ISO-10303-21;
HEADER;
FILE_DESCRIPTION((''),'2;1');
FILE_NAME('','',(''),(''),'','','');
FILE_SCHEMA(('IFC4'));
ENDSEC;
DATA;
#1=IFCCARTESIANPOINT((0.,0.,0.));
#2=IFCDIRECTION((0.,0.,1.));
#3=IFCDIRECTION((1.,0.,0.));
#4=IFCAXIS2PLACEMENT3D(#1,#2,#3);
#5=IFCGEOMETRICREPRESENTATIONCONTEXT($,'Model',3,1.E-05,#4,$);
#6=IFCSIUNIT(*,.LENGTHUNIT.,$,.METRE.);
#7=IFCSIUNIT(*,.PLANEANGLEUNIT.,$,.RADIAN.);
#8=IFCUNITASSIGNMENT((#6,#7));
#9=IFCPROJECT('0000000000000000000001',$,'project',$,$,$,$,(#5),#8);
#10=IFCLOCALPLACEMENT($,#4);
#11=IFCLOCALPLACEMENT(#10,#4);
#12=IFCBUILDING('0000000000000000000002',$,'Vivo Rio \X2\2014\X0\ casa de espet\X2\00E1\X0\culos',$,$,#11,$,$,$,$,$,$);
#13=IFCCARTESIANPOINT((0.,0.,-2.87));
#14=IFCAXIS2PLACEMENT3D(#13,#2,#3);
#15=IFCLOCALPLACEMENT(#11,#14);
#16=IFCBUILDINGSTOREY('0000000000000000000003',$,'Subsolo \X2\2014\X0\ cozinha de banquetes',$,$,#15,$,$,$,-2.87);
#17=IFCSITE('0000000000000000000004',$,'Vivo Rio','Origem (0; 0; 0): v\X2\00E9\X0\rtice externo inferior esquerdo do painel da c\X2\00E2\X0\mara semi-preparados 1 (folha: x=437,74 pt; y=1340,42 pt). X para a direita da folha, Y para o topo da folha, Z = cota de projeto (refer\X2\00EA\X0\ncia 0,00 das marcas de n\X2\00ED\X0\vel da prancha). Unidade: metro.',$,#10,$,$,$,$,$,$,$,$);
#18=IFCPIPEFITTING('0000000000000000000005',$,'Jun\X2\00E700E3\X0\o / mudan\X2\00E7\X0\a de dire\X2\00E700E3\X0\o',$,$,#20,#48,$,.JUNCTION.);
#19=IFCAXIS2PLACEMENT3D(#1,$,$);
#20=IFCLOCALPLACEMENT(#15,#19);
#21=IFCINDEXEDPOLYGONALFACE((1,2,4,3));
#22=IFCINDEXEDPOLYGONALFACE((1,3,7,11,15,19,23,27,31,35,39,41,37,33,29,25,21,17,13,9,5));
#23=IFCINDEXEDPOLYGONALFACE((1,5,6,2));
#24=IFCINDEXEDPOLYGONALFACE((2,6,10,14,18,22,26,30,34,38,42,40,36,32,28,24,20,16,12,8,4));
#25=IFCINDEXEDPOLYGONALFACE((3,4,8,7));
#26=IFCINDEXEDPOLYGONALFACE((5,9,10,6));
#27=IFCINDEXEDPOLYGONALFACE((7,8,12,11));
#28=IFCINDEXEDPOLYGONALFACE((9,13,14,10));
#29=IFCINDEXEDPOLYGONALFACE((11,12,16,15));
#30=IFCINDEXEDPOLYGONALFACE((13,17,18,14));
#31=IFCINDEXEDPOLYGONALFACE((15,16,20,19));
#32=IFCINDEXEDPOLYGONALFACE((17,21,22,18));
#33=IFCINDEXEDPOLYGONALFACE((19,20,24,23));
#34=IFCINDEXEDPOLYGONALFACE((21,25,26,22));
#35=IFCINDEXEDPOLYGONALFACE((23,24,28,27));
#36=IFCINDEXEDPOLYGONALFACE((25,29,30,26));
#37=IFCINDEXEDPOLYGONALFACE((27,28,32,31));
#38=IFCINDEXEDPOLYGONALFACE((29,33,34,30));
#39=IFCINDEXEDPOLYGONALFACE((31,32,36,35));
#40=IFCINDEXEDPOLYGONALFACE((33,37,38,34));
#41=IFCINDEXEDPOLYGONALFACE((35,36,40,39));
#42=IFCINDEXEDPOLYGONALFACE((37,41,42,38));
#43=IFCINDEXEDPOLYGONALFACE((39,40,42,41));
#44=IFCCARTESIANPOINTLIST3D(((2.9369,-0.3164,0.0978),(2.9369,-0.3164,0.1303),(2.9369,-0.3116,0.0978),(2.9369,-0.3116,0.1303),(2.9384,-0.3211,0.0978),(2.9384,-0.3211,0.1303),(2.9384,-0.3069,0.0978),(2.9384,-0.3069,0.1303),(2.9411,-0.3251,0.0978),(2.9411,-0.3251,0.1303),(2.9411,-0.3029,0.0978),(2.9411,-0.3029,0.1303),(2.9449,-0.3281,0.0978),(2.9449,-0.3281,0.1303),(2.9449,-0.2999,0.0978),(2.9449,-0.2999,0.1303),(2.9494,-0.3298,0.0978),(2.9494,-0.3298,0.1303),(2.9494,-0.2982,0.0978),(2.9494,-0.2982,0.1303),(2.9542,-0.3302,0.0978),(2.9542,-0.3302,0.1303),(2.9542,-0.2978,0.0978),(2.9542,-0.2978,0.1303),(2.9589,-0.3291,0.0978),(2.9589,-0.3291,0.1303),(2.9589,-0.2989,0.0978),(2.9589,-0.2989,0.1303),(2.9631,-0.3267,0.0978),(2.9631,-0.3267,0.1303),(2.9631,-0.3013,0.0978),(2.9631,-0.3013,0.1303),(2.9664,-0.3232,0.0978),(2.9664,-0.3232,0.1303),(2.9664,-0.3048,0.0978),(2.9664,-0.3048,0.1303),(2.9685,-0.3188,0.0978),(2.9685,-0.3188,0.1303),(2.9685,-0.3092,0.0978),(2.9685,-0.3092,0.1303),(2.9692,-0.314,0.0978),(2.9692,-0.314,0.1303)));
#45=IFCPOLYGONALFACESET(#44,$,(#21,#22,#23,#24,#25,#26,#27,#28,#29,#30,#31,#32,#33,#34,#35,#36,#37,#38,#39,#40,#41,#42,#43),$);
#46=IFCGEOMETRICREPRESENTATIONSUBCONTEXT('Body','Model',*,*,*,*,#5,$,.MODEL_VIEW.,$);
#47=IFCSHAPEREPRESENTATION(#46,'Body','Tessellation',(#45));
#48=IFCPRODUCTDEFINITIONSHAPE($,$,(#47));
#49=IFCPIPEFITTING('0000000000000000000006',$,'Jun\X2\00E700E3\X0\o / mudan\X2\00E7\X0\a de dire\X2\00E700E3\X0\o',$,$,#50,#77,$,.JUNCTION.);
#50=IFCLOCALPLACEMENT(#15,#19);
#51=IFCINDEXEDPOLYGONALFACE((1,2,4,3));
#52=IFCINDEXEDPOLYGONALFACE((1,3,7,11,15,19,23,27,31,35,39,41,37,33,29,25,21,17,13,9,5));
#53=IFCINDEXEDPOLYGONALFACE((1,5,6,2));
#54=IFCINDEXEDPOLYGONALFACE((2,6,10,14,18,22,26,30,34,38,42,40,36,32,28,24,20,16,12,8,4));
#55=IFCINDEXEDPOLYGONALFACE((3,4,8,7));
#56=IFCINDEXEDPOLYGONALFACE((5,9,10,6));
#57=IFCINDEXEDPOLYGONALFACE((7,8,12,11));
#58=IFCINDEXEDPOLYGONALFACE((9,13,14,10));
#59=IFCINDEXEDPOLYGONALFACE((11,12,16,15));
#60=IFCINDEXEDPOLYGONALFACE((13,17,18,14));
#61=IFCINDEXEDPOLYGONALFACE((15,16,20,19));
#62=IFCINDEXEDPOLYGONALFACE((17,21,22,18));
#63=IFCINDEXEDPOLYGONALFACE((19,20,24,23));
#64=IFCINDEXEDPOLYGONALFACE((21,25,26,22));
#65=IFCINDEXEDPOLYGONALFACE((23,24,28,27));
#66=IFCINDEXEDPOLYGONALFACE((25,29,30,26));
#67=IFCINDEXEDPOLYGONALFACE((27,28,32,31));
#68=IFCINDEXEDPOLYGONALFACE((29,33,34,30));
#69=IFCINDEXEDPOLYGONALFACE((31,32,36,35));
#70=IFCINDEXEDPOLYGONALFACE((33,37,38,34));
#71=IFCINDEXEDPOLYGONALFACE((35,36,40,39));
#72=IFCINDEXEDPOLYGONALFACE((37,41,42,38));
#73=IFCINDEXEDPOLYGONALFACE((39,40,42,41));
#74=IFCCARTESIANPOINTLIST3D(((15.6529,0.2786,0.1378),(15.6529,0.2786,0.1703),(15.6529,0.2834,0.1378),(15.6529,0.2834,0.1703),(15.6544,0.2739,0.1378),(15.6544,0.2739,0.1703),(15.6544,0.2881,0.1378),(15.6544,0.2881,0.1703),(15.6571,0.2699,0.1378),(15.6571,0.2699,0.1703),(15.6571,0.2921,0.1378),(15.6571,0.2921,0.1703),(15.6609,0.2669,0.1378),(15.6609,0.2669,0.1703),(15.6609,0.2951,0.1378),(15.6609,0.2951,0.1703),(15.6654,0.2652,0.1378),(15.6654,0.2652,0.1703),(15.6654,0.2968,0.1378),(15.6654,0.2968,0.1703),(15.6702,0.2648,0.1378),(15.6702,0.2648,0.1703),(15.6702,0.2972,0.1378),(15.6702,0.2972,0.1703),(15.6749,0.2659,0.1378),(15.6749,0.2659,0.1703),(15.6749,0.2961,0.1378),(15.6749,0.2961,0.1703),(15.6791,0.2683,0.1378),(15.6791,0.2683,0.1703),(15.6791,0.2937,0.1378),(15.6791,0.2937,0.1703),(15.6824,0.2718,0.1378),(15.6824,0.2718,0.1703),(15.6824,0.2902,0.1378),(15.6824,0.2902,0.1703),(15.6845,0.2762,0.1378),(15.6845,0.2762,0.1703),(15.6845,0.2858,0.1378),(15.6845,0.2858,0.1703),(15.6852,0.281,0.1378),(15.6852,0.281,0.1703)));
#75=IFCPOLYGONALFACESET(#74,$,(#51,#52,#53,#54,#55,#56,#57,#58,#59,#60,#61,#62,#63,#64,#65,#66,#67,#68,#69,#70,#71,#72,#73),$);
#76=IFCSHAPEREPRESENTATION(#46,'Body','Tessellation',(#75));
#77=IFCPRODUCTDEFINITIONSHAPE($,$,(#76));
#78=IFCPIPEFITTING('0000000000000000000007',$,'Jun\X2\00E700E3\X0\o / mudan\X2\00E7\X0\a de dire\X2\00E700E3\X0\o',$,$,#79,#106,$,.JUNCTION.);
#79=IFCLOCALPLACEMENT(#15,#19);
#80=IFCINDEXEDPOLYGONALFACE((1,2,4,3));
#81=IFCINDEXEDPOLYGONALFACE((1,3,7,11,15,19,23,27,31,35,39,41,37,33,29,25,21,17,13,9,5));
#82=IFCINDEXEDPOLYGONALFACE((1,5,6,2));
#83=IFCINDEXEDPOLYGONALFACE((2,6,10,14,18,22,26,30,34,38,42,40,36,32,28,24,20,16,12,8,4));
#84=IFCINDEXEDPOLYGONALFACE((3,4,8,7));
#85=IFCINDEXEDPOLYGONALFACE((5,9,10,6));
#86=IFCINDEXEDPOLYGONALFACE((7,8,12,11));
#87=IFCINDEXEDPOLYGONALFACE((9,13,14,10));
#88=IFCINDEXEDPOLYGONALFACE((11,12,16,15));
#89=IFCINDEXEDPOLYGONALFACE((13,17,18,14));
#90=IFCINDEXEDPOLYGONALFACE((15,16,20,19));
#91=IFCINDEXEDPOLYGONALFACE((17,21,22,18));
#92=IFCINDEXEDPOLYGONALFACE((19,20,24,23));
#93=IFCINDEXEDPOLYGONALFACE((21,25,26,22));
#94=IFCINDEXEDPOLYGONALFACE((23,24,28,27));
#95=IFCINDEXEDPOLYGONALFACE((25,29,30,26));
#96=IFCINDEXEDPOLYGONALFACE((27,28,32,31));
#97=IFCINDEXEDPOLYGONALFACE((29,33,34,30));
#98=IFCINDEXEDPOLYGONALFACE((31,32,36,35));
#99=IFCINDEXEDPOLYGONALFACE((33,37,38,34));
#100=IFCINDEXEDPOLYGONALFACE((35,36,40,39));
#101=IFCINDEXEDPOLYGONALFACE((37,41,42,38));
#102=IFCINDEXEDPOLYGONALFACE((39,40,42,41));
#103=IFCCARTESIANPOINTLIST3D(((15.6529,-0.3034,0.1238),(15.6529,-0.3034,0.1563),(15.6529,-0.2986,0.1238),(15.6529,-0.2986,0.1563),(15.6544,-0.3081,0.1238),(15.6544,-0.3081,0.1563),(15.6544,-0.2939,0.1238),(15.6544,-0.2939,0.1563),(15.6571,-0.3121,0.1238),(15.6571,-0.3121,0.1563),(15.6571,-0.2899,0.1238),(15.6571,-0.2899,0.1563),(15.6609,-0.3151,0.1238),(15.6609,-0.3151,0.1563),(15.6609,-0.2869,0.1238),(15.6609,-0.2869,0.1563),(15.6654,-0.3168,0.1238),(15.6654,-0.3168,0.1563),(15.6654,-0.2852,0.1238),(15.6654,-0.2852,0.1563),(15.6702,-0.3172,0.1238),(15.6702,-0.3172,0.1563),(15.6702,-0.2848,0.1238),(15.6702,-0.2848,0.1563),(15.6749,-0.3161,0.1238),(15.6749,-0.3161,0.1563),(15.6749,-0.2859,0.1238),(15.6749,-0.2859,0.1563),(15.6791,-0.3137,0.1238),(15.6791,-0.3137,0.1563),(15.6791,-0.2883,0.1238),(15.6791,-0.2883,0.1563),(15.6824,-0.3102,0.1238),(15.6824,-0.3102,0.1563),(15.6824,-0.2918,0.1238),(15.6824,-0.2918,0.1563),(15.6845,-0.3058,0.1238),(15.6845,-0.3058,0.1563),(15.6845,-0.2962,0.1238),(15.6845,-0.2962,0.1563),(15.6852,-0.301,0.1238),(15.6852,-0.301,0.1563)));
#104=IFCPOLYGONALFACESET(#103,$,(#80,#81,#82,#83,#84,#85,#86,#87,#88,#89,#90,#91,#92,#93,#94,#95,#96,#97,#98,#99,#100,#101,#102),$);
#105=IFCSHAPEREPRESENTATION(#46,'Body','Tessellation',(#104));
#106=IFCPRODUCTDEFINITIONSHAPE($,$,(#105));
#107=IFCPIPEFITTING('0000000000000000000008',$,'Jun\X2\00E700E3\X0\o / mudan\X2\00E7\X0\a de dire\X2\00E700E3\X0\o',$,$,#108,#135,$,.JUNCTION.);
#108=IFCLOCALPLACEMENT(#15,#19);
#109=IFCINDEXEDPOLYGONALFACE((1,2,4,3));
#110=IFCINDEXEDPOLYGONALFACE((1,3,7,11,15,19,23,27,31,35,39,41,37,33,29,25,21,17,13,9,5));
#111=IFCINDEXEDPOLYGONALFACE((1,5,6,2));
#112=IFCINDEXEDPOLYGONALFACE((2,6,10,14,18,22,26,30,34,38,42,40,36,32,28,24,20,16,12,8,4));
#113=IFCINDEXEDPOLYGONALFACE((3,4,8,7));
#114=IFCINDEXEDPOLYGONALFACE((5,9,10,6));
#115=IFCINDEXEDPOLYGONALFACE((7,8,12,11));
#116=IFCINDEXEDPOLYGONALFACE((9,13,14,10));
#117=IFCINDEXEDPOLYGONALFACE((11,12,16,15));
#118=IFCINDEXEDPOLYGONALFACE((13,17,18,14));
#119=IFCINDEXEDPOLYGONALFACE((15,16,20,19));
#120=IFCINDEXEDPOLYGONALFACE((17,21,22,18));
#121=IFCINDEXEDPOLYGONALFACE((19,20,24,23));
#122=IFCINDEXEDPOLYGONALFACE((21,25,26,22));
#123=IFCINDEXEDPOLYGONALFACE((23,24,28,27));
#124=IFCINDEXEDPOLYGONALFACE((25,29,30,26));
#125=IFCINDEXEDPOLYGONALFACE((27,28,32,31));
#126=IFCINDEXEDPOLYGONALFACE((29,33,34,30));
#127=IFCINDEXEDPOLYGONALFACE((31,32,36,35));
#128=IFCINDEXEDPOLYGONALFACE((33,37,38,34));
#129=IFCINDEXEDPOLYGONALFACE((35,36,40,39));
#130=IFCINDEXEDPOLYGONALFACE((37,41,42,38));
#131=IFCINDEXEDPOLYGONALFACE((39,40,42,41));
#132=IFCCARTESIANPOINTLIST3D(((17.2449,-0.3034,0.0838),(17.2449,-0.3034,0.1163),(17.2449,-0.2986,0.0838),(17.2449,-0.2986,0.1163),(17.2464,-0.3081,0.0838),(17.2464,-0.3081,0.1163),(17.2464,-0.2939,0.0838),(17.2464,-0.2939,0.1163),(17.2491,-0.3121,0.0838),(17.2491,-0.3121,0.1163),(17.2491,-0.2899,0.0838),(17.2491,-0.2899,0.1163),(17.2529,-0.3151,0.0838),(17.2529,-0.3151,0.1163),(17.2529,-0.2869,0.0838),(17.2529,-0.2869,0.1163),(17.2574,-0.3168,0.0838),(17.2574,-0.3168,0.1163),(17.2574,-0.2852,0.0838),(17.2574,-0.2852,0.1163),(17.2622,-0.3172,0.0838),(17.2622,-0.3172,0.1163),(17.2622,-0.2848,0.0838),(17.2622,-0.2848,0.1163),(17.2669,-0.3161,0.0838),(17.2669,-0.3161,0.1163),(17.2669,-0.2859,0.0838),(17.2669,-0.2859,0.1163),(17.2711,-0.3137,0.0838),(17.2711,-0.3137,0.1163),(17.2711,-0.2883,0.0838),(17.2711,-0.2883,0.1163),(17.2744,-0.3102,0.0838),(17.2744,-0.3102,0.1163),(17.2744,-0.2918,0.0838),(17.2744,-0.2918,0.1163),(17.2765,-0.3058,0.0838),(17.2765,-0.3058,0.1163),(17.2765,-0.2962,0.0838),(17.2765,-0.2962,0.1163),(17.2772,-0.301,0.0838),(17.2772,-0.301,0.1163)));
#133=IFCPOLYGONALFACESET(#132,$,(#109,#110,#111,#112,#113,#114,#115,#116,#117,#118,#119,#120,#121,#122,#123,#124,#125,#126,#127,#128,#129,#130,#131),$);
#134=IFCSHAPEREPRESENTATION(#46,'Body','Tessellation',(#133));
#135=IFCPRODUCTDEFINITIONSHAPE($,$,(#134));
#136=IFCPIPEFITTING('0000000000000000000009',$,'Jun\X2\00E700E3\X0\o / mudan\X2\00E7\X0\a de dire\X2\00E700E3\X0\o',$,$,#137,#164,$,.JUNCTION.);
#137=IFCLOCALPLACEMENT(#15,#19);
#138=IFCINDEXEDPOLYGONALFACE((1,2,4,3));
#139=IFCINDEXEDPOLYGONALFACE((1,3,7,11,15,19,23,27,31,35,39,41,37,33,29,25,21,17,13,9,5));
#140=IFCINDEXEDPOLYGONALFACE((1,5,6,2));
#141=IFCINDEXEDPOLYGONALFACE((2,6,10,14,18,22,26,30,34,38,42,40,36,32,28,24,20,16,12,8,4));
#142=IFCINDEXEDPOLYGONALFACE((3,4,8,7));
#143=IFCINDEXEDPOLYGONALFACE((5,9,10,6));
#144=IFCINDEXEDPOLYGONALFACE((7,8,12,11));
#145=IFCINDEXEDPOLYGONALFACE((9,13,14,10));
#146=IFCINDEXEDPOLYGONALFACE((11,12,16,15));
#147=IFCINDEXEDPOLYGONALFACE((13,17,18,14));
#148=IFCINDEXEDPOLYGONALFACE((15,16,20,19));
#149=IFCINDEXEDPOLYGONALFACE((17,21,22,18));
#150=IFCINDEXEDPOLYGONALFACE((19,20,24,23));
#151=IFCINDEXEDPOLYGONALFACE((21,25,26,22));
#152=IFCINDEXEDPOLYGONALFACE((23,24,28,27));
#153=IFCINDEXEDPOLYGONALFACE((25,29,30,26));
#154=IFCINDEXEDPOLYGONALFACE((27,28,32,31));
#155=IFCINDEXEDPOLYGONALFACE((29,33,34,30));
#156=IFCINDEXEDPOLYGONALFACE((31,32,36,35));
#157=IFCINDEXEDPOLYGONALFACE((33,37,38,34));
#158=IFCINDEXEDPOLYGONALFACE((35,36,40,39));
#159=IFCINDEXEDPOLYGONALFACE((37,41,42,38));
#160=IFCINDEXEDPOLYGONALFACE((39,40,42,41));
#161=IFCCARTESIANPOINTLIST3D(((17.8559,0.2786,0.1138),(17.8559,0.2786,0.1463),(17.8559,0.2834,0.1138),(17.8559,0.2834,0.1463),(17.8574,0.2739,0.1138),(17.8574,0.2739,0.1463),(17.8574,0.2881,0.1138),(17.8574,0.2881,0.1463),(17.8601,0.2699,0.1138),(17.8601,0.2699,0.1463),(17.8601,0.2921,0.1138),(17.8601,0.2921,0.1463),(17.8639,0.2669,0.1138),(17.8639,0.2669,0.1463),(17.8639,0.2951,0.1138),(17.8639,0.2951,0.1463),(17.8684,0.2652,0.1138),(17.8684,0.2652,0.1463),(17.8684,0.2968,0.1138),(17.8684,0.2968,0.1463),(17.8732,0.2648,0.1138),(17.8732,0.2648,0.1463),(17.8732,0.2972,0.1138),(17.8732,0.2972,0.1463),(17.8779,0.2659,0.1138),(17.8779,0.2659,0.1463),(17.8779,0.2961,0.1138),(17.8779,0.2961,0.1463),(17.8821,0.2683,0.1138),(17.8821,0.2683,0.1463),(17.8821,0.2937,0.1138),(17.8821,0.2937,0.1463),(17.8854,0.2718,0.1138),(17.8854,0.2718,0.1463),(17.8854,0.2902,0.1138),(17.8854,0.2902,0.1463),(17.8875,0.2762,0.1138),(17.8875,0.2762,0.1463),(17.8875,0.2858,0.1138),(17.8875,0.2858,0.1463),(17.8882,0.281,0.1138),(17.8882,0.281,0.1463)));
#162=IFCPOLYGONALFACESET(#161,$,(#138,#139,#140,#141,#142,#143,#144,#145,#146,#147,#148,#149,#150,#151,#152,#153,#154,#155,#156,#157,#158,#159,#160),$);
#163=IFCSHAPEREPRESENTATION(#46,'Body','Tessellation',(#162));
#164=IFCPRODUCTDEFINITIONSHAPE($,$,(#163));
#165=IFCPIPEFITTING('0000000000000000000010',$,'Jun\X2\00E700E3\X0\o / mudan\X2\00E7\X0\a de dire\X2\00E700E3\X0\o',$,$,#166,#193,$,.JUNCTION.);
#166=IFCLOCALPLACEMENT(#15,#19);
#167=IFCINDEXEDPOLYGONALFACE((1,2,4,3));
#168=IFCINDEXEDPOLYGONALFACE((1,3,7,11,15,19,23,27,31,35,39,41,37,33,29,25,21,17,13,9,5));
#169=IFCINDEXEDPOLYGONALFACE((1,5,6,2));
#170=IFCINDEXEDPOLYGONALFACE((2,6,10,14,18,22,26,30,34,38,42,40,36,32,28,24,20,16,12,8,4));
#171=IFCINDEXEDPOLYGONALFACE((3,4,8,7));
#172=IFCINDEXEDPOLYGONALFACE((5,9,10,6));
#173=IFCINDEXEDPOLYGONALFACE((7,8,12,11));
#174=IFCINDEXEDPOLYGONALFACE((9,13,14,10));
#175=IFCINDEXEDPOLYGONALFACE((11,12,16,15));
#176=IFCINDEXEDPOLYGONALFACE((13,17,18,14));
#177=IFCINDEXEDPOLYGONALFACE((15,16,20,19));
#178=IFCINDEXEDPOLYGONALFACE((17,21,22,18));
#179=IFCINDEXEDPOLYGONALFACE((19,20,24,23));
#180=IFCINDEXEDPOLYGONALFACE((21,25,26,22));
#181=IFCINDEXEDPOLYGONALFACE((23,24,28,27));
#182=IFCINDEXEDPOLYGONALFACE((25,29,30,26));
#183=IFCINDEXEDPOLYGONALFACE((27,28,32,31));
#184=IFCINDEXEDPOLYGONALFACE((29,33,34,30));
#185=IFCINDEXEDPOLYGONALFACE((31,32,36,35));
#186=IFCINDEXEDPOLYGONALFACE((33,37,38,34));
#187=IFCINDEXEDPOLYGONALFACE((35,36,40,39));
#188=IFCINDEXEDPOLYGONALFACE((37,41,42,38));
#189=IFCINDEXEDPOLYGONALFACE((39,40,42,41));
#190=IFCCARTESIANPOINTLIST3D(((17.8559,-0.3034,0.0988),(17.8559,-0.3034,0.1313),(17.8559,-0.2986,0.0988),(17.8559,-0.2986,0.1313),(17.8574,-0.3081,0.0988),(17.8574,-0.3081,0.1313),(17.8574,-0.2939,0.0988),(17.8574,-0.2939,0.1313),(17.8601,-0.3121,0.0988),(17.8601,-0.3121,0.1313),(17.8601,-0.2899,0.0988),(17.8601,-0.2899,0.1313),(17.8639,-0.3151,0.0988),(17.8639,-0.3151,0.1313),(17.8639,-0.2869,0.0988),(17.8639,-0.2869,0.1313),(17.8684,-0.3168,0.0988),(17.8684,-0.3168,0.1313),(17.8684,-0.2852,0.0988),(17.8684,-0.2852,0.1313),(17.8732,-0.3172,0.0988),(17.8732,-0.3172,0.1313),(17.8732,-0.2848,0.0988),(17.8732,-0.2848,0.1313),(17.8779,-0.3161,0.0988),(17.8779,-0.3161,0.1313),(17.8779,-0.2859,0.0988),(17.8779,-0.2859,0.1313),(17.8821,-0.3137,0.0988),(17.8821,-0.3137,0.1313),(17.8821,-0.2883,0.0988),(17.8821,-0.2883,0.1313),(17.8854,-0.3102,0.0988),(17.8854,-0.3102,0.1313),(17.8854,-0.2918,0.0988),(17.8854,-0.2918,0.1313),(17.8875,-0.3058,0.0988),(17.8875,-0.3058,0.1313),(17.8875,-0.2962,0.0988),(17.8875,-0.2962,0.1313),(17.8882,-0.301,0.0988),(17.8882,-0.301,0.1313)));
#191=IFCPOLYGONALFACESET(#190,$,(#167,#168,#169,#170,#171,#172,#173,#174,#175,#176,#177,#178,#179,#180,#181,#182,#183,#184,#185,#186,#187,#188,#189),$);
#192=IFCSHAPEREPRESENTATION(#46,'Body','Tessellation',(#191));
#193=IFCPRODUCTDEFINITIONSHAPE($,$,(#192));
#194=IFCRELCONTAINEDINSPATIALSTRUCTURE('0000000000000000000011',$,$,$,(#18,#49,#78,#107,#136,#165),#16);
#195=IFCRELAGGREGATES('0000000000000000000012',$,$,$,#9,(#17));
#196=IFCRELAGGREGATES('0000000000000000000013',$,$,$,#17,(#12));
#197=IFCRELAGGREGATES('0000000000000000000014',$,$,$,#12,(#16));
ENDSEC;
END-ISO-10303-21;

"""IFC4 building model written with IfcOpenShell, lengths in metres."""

from ifc_helpers import new_model, si_unit, frame, origin_with_axes, origin_2d, place, context, subcontext, project, spatial, circle, extrude, element, save


model = new_model("IFC4")

# Units and contexts
model_context = context("Model", 3, precision=1e-05, world=origin_with_axes())
body_context = subcontext(model_context, "Body", "Model", "MODEL_VIEW")
ifc_project = project(units=[si_unit("LENGTHUNIT", "METRE"), si_unit("PLANEANGLEUNIT", "RADIAN")], contexts=[model_context])

# Site, building, storey
site_placement = place(None, origin_with_axes())
site = spatial("IfcSite", under=ifc_project, at=site_placement, Name="Vivo Rio", Description="Origem (0; 0; 0): vértice externo inferior esquerdo do painel da câmara semi-preparados 1 (folha: x=437,74 pt; y=1340,42 pt). X para a direita da folha, Y para o topo da folha, Z = cota de projeto (referência 0,00 das marcas de nível da prancha). Unidade: metro.")
building_placement = place(site_placement, origin_with_axes())
building = spatial("IfcBuilding", under=site, at=building_placement, Name="Vivo Rio — casa de espetáculos")
storey_placement = place(building_placement, frame((0.0, 0.0, -2.87), z_axis=(0.0, 0.0, 1.0), x_axis=(1.0, 0.0, 0.0)))
storey = spatial("IfcBuildingStorey", under=building, at=storey_placement, Name="Subsolo — cozinha de banquetes", Elevation=-2.87)

# Pipe fittings
pipe_fitting_1_placement = place(storey_placement, origin_with_axes())
element("IfcPipeFitting", 1, at=pipe_fitting_1_placement, inside=storey, Name="Junção / mudança de direção", PredefinedType="JUNCTION", context=body_context, shape_type="SweptSolid", body=[
    extrude(circle(Radius=0.0163, at=origin_2d()), frame((2.953, -0.314, 0.0978), z_axis=(0.0, 0.0, 1.0), x_axis=(1.0, 0.0, 0.0)), (0.0, 0.0, 1.0), 0.0325),
])
pipe_fitting_2_placement = place(storey_placement, origin_with_axes())
element("IfcPipeFitting", 2, at=pipe_fitting_2_placement, inside=storey, Name="Junção / mudança de direção", PredefinedType="JUNCTION", context=body_context, shape_type="SweptSolid", body=[
    extrude(circle(Radius=0.0163, at=origin_2d()), frame((15.669, 0.281, 0.1378), z_axis=(0.0, 0.0, 1.0), x_axis=(1.0, 0.0, 0.0)), (0.0, 0.0, 1.0), 0.0325),
])
pipe_fitting_3_placement = place(storey_placement, origin_with_axes())
element("IfcPipeFitting", 3, at=pipe_fitting_3_placement, inside=storey, Name="Junção / mudança de direção", PredefinedType="JUNCTION", context=body_context, shape_type="SweptSolid", body=[
    extrude(circle(Radius=0.0163, at=origin_2d()), frame((15.669, -0.301, 0.1238), z_axis=(0.0, 0.0, 1.0), x_axis=(1.0, 0.0, 0.0)), (0.0, 0.0, 1.0), 0.0325),
])
pipe_fitting_4_placement = place(storey_placement, origin_with_axes())
element("IfcPipeFitting", 4, at=pipe_fitting_4_placement, inside=storey, Name="Junção / mudança de direção", PredefinedType="JUNCTION", context=body_context, shape_type="SweptSolid", body=[
    extrude(circle(Radius=0.0163, at=origin_2d()), frame((17.261, -0.301, 0.0838), z_axis=(0.0, 0.0, 1.0), x_axis=(1.0, 0.0, 0.0)), (0.0, 0.0, 1.0), 0.0325),
])
pipe_fitting_5_placement = place(storey_placement, origin_with_axes())
element("IfcPipeFitting", 5, at=pipe_fitting_5_placement, inside=storey, Name="Junção / mudança de direção", PredefinedType="JUNCTION", context=body_context, shape_type="SweptSolid", body=[
    extrude(circle(Radius=0.0163, at=origin_2d()), frame((17.872, 0.281, 0.1138), z_axis=(0.0, 0.0, 1.0), x_axis=(1.0, 0.0, 0.0)), (0.0, 0.0, 1.0), 0.0325),
])
pipe_fitting_6_placement = place(storey_placement, origin_with_axes())
element("IfcPipeFitting", 6, at=pipe_fitting_6_placement, inside=storey, Name="Junção / mudança de direção", PredefinedType="JUNCTION", context=body_context, shape_type="SweptSolid", body=[
    extrude(circle(Radius=0.0163, at=origin_2d()), frame((17.872, -0.301, 0.0988), z_axis=(0.0, 0.0, 1.0), x_axis=(1.0, 0.0, 0.0)), (0.0, 0.0, 1.0), 0.0325),
])

save(model, "model.ifc")
